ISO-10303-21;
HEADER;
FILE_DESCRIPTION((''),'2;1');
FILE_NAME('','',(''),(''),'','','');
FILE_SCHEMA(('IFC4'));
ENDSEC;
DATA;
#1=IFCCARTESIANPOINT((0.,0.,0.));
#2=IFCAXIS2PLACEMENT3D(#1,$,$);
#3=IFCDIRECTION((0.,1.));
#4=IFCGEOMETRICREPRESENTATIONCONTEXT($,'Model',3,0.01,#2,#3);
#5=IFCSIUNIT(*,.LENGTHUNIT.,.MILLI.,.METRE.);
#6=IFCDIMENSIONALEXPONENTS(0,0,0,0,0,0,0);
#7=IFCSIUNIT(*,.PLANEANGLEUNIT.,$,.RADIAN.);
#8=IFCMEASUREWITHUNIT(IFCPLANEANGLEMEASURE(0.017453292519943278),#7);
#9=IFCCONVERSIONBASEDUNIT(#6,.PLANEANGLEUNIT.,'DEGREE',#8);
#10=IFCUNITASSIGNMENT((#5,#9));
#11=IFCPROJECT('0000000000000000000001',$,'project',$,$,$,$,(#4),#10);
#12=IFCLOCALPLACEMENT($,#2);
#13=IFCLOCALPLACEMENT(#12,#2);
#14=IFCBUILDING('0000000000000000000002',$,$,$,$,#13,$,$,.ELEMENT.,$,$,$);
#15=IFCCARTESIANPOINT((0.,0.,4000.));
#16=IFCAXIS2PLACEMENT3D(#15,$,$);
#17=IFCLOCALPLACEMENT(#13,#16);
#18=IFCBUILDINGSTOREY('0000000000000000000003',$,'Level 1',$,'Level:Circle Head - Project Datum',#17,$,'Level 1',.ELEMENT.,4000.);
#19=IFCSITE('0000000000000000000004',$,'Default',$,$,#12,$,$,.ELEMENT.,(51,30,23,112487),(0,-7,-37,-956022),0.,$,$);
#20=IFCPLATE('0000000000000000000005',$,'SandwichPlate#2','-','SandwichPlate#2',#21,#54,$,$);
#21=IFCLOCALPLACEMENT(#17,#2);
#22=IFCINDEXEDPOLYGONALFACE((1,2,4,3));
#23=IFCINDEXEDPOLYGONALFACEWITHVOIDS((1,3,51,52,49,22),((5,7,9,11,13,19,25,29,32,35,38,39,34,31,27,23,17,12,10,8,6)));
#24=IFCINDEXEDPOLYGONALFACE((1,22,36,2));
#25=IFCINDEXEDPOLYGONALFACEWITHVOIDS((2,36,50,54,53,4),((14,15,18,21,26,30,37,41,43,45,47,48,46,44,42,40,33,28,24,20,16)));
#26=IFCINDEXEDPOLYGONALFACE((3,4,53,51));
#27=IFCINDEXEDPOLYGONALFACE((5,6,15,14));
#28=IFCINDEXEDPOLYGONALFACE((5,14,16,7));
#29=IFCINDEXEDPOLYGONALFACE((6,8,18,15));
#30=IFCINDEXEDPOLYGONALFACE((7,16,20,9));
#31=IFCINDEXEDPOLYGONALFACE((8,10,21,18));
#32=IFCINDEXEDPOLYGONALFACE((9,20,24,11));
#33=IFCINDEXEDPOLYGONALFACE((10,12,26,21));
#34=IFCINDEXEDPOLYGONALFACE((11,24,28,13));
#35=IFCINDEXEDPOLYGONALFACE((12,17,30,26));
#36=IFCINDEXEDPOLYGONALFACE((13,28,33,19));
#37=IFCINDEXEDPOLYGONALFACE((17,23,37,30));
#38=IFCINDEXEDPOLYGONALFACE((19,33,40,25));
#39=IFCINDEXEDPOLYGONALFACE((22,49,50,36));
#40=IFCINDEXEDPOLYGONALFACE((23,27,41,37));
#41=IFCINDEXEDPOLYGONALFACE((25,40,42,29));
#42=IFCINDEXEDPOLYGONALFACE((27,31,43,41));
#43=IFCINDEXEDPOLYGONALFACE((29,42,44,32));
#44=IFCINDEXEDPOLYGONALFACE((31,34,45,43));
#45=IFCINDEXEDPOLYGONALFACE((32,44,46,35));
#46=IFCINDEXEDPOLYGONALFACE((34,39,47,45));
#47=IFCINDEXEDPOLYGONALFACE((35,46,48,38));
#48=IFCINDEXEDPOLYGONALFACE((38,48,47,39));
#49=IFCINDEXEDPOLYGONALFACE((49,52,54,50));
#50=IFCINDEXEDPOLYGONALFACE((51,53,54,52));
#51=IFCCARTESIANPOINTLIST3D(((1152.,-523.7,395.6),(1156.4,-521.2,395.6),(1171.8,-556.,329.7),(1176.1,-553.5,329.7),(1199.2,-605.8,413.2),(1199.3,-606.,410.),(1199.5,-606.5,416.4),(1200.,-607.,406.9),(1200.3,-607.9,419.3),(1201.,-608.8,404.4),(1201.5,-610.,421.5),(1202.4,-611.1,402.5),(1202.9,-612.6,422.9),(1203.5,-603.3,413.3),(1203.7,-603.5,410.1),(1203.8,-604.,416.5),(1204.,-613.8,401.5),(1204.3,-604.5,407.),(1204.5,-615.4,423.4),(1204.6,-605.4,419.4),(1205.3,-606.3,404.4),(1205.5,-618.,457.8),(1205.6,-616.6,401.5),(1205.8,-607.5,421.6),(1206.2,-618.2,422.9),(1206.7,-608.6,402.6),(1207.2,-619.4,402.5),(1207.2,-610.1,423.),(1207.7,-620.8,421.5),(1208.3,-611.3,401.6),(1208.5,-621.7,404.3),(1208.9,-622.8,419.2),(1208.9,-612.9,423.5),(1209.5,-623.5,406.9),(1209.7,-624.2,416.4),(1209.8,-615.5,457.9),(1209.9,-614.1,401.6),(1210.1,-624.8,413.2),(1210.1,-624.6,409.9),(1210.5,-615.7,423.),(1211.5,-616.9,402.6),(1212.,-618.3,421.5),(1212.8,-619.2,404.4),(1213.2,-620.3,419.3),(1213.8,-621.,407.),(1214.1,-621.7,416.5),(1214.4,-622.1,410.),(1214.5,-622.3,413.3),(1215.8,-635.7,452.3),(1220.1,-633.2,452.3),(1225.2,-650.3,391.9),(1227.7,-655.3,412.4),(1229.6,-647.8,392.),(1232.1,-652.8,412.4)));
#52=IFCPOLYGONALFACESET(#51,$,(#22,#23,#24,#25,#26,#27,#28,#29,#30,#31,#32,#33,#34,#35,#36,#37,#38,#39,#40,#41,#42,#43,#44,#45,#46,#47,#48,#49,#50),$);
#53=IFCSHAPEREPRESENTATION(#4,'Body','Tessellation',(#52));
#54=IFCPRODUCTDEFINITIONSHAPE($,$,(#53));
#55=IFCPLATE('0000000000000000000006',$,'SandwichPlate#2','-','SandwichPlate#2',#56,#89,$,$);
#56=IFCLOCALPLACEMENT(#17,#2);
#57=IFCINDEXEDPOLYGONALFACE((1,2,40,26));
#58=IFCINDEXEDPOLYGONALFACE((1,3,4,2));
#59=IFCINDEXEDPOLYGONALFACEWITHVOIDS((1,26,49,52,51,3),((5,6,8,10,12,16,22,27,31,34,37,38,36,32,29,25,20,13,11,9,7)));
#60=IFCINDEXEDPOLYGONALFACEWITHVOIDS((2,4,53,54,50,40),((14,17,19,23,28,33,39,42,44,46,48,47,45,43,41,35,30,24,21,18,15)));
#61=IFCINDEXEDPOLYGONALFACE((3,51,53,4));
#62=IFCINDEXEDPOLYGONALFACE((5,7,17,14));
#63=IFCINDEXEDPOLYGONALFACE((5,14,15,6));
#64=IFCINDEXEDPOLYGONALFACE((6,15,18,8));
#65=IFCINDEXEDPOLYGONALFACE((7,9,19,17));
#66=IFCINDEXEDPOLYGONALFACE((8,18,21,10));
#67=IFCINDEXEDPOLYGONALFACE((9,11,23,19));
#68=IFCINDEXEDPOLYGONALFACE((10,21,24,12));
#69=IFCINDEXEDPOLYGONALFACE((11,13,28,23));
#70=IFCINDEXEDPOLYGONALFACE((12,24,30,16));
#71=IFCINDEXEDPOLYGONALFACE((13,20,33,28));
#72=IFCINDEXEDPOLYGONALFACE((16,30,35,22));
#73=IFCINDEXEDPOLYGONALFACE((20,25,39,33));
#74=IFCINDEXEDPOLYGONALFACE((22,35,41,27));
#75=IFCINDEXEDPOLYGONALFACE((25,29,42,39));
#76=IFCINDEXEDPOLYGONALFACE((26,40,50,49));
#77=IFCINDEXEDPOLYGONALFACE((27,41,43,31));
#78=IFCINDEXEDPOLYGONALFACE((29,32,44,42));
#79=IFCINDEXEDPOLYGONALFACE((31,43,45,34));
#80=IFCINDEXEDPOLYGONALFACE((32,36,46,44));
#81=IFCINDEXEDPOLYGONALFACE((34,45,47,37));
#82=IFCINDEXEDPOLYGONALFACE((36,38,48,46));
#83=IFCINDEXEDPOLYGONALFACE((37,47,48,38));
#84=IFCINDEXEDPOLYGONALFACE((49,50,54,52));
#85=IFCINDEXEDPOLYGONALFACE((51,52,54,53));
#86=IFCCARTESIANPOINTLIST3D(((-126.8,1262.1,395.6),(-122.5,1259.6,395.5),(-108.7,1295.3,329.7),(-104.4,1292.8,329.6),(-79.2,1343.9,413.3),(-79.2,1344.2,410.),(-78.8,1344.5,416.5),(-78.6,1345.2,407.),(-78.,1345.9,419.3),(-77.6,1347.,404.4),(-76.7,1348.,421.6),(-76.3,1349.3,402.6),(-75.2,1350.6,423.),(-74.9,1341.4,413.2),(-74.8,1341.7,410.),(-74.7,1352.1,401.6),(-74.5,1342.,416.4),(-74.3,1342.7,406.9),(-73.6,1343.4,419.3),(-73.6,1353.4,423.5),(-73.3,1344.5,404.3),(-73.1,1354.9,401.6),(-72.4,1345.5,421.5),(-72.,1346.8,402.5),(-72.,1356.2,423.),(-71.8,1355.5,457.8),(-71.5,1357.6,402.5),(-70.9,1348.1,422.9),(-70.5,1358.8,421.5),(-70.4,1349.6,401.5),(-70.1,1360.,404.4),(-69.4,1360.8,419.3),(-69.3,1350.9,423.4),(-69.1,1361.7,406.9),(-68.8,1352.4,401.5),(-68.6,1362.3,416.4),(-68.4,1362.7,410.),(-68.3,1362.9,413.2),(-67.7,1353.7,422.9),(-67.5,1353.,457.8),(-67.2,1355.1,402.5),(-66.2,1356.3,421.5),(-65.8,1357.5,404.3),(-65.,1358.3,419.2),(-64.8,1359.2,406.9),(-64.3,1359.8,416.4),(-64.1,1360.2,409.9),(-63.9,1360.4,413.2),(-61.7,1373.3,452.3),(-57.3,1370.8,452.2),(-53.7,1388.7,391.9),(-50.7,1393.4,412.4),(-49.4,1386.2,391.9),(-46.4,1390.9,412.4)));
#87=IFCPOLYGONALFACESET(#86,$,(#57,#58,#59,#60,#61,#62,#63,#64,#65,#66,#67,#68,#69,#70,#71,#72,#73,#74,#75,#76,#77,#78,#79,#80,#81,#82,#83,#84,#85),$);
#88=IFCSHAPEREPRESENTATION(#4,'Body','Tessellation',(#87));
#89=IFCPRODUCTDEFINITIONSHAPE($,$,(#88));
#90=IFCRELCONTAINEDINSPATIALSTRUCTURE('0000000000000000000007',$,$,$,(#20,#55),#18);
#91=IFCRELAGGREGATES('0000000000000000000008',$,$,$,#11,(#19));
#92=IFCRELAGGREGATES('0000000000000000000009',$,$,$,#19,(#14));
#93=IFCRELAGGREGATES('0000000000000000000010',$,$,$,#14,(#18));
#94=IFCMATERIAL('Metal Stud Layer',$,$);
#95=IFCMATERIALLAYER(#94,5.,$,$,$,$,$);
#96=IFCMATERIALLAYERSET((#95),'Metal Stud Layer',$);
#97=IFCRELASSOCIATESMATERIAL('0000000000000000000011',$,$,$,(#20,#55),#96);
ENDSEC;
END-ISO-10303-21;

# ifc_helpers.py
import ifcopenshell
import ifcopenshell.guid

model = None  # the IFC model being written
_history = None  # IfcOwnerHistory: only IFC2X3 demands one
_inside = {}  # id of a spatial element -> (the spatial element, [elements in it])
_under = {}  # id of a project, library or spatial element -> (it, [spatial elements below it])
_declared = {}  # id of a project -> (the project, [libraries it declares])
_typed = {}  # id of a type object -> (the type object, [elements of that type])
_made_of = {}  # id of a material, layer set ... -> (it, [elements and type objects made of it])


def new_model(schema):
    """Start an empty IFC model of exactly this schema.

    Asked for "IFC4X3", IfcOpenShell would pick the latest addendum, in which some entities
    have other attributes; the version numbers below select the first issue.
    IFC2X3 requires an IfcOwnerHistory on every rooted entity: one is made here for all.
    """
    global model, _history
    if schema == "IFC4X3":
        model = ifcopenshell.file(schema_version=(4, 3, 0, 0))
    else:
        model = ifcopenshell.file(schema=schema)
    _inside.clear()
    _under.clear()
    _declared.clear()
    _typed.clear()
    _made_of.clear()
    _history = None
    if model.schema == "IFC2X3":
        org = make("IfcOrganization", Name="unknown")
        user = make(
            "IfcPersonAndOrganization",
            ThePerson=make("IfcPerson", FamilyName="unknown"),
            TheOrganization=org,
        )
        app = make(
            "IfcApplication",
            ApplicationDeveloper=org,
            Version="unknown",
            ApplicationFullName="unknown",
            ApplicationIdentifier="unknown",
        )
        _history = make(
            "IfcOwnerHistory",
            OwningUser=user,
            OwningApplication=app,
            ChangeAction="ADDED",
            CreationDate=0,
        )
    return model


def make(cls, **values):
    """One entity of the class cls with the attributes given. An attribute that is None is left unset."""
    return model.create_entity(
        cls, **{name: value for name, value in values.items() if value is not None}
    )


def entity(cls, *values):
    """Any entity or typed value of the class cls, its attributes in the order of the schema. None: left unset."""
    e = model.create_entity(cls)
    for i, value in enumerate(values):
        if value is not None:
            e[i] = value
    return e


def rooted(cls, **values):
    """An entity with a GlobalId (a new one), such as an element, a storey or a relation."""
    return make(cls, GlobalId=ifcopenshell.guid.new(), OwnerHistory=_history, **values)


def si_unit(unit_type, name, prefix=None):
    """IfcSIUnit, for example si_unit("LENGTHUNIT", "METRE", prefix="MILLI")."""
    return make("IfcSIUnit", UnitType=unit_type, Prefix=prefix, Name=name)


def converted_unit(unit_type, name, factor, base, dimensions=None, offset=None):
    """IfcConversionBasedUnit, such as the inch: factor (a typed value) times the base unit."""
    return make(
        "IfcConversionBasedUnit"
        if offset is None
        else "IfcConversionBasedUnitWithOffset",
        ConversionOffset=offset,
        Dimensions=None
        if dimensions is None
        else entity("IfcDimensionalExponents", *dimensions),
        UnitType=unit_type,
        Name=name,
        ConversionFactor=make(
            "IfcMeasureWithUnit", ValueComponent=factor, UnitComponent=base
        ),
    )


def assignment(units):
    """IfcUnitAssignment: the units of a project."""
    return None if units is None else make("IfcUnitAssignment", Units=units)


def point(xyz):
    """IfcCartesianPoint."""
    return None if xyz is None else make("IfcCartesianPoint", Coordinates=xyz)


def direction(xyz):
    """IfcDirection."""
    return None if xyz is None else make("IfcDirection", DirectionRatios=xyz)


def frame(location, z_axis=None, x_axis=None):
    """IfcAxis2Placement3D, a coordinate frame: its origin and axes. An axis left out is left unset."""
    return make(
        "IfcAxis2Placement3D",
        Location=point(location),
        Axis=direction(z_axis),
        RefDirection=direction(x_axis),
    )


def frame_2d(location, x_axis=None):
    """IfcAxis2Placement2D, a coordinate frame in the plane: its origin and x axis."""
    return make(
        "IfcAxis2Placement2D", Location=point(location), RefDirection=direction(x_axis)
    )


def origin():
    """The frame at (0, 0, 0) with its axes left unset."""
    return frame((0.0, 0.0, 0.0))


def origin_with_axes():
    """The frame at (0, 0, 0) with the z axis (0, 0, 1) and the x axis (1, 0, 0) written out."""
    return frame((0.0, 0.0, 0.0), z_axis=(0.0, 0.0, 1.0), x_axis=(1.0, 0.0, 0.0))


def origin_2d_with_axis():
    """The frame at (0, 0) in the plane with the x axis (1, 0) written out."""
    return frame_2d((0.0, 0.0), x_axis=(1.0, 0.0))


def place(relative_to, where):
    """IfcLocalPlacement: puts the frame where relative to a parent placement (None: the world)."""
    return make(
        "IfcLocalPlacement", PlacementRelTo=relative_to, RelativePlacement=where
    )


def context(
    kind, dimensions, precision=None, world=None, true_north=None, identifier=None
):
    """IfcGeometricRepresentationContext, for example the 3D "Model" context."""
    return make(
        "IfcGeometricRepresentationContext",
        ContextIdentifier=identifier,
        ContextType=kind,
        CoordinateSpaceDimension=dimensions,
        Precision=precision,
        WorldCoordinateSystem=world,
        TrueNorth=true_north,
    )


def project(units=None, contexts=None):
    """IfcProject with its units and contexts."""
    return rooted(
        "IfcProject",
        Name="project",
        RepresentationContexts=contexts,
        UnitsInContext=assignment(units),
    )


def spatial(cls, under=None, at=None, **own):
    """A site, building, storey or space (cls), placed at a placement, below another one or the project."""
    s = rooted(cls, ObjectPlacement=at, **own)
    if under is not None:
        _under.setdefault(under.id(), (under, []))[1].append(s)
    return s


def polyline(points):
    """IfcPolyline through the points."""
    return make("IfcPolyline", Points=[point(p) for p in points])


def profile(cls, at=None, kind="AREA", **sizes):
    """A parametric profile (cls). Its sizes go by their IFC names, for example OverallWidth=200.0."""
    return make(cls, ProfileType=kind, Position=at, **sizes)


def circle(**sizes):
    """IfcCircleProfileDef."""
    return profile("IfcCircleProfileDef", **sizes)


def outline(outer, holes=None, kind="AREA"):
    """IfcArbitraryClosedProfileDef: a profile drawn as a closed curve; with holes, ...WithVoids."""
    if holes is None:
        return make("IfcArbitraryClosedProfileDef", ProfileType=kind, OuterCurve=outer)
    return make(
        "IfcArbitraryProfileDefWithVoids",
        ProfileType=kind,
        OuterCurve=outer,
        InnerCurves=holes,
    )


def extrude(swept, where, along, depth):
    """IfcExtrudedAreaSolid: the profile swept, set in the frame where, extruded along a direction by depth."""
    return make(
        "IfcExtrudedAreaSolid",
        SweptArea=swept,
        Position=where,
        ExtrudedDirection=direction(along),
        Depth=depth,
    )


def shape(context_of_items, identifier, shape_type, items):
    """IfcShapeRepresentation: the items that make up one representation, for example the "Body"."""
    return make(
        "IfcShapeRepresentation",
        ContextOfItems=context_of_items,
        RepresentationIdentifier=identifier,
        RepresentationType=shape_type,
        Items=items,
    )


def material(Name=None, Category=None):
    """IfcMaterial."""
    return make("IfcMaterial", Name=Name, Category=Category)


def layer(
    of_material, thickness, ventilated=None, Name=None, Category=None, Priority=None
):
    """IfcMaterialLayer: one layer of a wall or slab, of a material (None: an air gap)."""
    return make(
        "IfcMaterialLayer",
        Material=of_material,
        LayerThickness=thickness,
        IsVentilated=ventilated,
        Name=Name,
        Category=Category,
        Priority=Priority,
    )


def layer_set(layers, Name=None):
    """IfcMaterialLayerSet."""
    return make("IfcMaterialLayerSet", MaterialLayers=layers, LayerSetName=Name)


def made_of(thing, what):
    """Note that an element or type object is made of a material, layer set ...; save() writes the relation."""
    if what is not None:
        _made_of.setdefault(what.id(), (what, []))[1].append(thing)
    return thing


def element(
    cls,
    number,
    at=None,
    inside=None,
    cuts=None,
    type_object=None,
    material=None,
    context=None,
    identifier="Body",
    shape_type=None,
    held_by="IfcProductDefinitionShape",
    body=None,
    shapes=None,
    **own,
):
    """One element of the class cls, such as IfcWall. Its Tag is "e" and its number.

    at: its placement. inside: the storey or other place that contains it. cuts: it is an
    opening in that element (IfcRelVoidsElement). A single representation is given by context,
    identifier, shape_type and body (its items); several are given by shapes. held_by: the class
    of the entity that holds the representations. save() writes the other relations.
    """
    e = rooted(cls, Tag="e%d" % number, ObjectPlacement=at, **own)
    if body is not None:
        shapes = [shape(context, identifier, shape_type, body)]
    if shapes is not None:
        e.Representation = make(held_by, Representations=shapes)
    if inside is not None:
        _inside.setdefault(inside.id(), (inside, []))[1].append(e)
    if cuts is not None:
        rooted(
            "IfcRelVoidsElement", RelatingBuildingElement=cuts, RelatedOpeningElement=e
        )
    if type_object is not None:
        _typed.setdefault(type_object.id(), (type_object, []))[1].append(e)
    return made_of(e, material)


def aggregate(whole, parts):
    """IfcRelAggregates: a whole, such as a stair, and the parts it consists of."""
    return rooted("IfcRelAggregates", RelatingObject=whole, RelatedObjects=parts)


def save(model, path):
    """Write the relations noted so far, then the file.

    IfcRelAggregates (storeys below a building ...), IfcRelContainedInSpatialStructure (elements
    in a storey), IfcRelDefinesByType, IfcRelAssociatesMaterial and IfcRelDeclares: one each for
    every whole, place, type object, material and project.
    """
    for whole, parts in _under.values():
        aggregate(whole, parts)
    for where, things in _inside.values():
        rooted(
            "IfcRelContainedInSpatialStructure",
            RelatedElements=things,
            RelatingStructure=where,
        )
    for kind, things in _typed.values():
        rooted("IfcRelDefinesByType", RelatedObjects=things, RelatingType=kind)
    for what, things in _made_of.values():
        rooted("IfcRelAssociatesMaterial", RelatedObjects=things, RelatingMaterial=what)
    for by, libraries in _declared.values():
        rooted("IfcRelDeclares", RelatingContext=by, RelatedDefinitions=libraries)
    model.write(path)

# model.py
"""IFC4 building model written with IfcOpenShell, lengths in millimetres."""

from ifc_helpers import new_model, entity, si_unit, converted_unit, direction, frame, origin, origin_with_axes, origin_2d_with_axis, place, context, project, spatial, polyline, circle, outline, extrude, material, layer, layer_set, element, save


model = new_model("IFC4")

# Units and contexts
model_context = context("Model", 3, precision=0.01, world=origin(), true_north=direction((0.0, 1.0)))
ifc_project = project(units=[si_unit("LENGTHUNIT", "METRE", prefix="MILLI"), converted_unit("PLANEANGLEUNIT", "DEGREE", entity("IfcPlaneAngleMeasure", 0.017453292519943278), si_unit("PLANEANGLEUNIT", "RADIAN"), dimensions=[0, 0, 0, 0, 0, 0, 0])], contexts=[model_context])

# Site, building, storey
site_placement = place(None, origin())
site = spatial("IfcSite", under=ifc_project, at=site_placement, Name="Default", CompositionType="ELEMENT", RefLatitude=(51, 30, 23, 112487), RefLongitude=(0, -7, -37, -956022), RefElevation=0.0)
building_placement = place(site_placement, origin())
building = spatial("IfcBuilding", under=site, at=building_placement, CompositionType="ELEMENT")
storey_placement = place(building_placement, frame((0.0, 0.0, 4000.0)))
storey = spatial("IfcBuildingStorey", under=building, at=storey_placement, Name="Level 1", ObjectType="Level:Circle Head - Project Datum", LongName="Level 1", CompositionType="ELEMENT", Elevation=4000.0)

# Plates, openings
ifc_material_1 = material(Name="Metal Stud Layer")
ifc_layer = layer(ifc_material_1, 5.0)
ifc_layer_set = layer_set([ifc_layer], Name="Metal Stud Layer")
plate_1_placement = place(storey_placement, frame((1236.0, -659.2, 399.4), z_axis=(-0.865935, -0.499948, -0.014432), x_axis=(-0.259821, 0.424992, 0.867107)))
plate_1 = element("IfcPlate", 1, at=plate_1_placement, inside=storey, material=ifc_layer_set, Name="SandwichPlate#2", Description="-", ObjectType="SandwichPlate#2", context=model_context, shape_type="SweptSolid", body=[
    extrude(outline(polyline([(0.0, 0.0), (76.0, 0.0), (76.0, 140.0), (0.0, 140.0), (0.0, 0.0)])), origin_with_axes(), (0.0, 0.0, 1.0), 5.0),
])
opening_1_placement = place(plate_1_placement, frame((0.0, 0.0, 0.0), z_axis=(0.0, 0.0, 1.0), x_axis=(1.0, 0.0, 0.0)))
element("IfcOpeningElement", 2, at=opening_1_placement, cuts=plate_1, ObjectType="Opening", context=model_context, shape_type="SweptSolid", body=[
    extrude(outline(polyline([(0.0, 0.0), (15.0, 0.0), (0.0, 15.0), (0.0, 0.0)])), origin(), (0.0, 0.0, 1.0), 5.0),
])
opening_2_placement = place(plate_1_placement, frame((0.0, 0.0, 0.0), z_axis=(0.0, 0.0, 1.0), x_axis=(1.0, 0.0, 0.0)))
element("IfcOpeningElement", 3, at=opening_2_placement, cuts=plate_1, ObjectType="Opening", context=model_context, shape_type="SweptSolid", body=[
    extrude(outline(polyline([(76.0, 0.0), (76.0, 15.0), (61.0, 0.0), (76.0, 0.0)])), origin(), (0.0, 0.0, 1.0), 5.0),
])
opening_3_placement = place(plate_1_placement, frame((38.0, 40.0, -0.5), z_axis=(0.0, 0.0, 1.0), x_axis=(0.0, 1.0, 0.0)))
element("IfcOpeningElement", 4, at=opening_3_placement, cuts=plate_1, ObjectType="Opening", context=model_context, shape_type="SweptSolid", body=[
    extrude(circle(Radius=11.0, at=origin_2d_with_axis()), origin(), (0.0, 0.0, 1.0), 6.0),
])
plate_2_placement = place(storey_placement, frame((-47.1, 1400.0, 399.4), z_axis=(0.865935, -0.499948, -0.014432), x_axis=(-0.238139, -0.437501, 0.867112)))
plate_2 = element("IfcPlate", 5, at=plate_2_placement, inside=storey, material=ifc_layer_set, Name="SandwichPlate#2", Description="-", ObjectType="SandwichPlate#2", context=model_context, shape_type="SweptSolid", body=[
    extrude(outline(polyline([(0.0, 0.0), (76.0, 0.0), (76.0, 140.0), (0.0, 140.0), (0.0, 0.0)])), origin_with_axes(), (0.0, 0.0, 1.0), 5.0),
])
opening_4_placement = place(plate_2_placement, frame((0.0, 0.0, 0.0), z_axis=(0.0, 0.0, 1.0), x_axis=(1.0, 0.0, 0.0)))
element("IfcOpeningElement", 6, at=opening_4_placement, cuts=plate_2, ObjectType="Opening", context=model_context, shape_type="SweptSolid", body=[
    extrude(outline(polyline([(0.0, 0.0), (15.0, 0.0), (0.0, 15.0), (0.0, 0.0)])), origin(), (0.0, 0.0, 1.0), 5.0),
])
opening_5_placement = place(plate_2_placement, frame((0.0, 0.0, 0.0), z_axis=(0.0, 0.0, 1.0), x_axis=(1.0, 0.0, 0.0)))
element("IfcOpeningElement", 7, at=opening_5_placement, cuts=plate_2, ObjectType="Opening", context=model_context, shape_type="SweptSolid", body=[
    extrude(outline(polyline([(76.0, 0.0), (76.0, 15.0), (61.0, 0.0), (76.0, 0.0)])), origin(), (0.0, 0.0, 1.0), 5.0),
])
opening_6_placement = place(plate_2_placement, frame((38.0, 40.0, -0.5), z_axis=(0.0, 0.0, 1.0), x_axis=(0.0, 1.0, 0.0)))
element("IfcOpeningElement", 8, at=opening_6_placement, cuts=plate_2, ObjectType="Opening", context=model_context, shape_type="SweptSolid", body=[
    extrude(circle(Radius=11.0, at=origin_2d_with_axis()), origin(), (0.0, 0.0, 1.0), 6.0),
])

save(model, "model.ifc")
